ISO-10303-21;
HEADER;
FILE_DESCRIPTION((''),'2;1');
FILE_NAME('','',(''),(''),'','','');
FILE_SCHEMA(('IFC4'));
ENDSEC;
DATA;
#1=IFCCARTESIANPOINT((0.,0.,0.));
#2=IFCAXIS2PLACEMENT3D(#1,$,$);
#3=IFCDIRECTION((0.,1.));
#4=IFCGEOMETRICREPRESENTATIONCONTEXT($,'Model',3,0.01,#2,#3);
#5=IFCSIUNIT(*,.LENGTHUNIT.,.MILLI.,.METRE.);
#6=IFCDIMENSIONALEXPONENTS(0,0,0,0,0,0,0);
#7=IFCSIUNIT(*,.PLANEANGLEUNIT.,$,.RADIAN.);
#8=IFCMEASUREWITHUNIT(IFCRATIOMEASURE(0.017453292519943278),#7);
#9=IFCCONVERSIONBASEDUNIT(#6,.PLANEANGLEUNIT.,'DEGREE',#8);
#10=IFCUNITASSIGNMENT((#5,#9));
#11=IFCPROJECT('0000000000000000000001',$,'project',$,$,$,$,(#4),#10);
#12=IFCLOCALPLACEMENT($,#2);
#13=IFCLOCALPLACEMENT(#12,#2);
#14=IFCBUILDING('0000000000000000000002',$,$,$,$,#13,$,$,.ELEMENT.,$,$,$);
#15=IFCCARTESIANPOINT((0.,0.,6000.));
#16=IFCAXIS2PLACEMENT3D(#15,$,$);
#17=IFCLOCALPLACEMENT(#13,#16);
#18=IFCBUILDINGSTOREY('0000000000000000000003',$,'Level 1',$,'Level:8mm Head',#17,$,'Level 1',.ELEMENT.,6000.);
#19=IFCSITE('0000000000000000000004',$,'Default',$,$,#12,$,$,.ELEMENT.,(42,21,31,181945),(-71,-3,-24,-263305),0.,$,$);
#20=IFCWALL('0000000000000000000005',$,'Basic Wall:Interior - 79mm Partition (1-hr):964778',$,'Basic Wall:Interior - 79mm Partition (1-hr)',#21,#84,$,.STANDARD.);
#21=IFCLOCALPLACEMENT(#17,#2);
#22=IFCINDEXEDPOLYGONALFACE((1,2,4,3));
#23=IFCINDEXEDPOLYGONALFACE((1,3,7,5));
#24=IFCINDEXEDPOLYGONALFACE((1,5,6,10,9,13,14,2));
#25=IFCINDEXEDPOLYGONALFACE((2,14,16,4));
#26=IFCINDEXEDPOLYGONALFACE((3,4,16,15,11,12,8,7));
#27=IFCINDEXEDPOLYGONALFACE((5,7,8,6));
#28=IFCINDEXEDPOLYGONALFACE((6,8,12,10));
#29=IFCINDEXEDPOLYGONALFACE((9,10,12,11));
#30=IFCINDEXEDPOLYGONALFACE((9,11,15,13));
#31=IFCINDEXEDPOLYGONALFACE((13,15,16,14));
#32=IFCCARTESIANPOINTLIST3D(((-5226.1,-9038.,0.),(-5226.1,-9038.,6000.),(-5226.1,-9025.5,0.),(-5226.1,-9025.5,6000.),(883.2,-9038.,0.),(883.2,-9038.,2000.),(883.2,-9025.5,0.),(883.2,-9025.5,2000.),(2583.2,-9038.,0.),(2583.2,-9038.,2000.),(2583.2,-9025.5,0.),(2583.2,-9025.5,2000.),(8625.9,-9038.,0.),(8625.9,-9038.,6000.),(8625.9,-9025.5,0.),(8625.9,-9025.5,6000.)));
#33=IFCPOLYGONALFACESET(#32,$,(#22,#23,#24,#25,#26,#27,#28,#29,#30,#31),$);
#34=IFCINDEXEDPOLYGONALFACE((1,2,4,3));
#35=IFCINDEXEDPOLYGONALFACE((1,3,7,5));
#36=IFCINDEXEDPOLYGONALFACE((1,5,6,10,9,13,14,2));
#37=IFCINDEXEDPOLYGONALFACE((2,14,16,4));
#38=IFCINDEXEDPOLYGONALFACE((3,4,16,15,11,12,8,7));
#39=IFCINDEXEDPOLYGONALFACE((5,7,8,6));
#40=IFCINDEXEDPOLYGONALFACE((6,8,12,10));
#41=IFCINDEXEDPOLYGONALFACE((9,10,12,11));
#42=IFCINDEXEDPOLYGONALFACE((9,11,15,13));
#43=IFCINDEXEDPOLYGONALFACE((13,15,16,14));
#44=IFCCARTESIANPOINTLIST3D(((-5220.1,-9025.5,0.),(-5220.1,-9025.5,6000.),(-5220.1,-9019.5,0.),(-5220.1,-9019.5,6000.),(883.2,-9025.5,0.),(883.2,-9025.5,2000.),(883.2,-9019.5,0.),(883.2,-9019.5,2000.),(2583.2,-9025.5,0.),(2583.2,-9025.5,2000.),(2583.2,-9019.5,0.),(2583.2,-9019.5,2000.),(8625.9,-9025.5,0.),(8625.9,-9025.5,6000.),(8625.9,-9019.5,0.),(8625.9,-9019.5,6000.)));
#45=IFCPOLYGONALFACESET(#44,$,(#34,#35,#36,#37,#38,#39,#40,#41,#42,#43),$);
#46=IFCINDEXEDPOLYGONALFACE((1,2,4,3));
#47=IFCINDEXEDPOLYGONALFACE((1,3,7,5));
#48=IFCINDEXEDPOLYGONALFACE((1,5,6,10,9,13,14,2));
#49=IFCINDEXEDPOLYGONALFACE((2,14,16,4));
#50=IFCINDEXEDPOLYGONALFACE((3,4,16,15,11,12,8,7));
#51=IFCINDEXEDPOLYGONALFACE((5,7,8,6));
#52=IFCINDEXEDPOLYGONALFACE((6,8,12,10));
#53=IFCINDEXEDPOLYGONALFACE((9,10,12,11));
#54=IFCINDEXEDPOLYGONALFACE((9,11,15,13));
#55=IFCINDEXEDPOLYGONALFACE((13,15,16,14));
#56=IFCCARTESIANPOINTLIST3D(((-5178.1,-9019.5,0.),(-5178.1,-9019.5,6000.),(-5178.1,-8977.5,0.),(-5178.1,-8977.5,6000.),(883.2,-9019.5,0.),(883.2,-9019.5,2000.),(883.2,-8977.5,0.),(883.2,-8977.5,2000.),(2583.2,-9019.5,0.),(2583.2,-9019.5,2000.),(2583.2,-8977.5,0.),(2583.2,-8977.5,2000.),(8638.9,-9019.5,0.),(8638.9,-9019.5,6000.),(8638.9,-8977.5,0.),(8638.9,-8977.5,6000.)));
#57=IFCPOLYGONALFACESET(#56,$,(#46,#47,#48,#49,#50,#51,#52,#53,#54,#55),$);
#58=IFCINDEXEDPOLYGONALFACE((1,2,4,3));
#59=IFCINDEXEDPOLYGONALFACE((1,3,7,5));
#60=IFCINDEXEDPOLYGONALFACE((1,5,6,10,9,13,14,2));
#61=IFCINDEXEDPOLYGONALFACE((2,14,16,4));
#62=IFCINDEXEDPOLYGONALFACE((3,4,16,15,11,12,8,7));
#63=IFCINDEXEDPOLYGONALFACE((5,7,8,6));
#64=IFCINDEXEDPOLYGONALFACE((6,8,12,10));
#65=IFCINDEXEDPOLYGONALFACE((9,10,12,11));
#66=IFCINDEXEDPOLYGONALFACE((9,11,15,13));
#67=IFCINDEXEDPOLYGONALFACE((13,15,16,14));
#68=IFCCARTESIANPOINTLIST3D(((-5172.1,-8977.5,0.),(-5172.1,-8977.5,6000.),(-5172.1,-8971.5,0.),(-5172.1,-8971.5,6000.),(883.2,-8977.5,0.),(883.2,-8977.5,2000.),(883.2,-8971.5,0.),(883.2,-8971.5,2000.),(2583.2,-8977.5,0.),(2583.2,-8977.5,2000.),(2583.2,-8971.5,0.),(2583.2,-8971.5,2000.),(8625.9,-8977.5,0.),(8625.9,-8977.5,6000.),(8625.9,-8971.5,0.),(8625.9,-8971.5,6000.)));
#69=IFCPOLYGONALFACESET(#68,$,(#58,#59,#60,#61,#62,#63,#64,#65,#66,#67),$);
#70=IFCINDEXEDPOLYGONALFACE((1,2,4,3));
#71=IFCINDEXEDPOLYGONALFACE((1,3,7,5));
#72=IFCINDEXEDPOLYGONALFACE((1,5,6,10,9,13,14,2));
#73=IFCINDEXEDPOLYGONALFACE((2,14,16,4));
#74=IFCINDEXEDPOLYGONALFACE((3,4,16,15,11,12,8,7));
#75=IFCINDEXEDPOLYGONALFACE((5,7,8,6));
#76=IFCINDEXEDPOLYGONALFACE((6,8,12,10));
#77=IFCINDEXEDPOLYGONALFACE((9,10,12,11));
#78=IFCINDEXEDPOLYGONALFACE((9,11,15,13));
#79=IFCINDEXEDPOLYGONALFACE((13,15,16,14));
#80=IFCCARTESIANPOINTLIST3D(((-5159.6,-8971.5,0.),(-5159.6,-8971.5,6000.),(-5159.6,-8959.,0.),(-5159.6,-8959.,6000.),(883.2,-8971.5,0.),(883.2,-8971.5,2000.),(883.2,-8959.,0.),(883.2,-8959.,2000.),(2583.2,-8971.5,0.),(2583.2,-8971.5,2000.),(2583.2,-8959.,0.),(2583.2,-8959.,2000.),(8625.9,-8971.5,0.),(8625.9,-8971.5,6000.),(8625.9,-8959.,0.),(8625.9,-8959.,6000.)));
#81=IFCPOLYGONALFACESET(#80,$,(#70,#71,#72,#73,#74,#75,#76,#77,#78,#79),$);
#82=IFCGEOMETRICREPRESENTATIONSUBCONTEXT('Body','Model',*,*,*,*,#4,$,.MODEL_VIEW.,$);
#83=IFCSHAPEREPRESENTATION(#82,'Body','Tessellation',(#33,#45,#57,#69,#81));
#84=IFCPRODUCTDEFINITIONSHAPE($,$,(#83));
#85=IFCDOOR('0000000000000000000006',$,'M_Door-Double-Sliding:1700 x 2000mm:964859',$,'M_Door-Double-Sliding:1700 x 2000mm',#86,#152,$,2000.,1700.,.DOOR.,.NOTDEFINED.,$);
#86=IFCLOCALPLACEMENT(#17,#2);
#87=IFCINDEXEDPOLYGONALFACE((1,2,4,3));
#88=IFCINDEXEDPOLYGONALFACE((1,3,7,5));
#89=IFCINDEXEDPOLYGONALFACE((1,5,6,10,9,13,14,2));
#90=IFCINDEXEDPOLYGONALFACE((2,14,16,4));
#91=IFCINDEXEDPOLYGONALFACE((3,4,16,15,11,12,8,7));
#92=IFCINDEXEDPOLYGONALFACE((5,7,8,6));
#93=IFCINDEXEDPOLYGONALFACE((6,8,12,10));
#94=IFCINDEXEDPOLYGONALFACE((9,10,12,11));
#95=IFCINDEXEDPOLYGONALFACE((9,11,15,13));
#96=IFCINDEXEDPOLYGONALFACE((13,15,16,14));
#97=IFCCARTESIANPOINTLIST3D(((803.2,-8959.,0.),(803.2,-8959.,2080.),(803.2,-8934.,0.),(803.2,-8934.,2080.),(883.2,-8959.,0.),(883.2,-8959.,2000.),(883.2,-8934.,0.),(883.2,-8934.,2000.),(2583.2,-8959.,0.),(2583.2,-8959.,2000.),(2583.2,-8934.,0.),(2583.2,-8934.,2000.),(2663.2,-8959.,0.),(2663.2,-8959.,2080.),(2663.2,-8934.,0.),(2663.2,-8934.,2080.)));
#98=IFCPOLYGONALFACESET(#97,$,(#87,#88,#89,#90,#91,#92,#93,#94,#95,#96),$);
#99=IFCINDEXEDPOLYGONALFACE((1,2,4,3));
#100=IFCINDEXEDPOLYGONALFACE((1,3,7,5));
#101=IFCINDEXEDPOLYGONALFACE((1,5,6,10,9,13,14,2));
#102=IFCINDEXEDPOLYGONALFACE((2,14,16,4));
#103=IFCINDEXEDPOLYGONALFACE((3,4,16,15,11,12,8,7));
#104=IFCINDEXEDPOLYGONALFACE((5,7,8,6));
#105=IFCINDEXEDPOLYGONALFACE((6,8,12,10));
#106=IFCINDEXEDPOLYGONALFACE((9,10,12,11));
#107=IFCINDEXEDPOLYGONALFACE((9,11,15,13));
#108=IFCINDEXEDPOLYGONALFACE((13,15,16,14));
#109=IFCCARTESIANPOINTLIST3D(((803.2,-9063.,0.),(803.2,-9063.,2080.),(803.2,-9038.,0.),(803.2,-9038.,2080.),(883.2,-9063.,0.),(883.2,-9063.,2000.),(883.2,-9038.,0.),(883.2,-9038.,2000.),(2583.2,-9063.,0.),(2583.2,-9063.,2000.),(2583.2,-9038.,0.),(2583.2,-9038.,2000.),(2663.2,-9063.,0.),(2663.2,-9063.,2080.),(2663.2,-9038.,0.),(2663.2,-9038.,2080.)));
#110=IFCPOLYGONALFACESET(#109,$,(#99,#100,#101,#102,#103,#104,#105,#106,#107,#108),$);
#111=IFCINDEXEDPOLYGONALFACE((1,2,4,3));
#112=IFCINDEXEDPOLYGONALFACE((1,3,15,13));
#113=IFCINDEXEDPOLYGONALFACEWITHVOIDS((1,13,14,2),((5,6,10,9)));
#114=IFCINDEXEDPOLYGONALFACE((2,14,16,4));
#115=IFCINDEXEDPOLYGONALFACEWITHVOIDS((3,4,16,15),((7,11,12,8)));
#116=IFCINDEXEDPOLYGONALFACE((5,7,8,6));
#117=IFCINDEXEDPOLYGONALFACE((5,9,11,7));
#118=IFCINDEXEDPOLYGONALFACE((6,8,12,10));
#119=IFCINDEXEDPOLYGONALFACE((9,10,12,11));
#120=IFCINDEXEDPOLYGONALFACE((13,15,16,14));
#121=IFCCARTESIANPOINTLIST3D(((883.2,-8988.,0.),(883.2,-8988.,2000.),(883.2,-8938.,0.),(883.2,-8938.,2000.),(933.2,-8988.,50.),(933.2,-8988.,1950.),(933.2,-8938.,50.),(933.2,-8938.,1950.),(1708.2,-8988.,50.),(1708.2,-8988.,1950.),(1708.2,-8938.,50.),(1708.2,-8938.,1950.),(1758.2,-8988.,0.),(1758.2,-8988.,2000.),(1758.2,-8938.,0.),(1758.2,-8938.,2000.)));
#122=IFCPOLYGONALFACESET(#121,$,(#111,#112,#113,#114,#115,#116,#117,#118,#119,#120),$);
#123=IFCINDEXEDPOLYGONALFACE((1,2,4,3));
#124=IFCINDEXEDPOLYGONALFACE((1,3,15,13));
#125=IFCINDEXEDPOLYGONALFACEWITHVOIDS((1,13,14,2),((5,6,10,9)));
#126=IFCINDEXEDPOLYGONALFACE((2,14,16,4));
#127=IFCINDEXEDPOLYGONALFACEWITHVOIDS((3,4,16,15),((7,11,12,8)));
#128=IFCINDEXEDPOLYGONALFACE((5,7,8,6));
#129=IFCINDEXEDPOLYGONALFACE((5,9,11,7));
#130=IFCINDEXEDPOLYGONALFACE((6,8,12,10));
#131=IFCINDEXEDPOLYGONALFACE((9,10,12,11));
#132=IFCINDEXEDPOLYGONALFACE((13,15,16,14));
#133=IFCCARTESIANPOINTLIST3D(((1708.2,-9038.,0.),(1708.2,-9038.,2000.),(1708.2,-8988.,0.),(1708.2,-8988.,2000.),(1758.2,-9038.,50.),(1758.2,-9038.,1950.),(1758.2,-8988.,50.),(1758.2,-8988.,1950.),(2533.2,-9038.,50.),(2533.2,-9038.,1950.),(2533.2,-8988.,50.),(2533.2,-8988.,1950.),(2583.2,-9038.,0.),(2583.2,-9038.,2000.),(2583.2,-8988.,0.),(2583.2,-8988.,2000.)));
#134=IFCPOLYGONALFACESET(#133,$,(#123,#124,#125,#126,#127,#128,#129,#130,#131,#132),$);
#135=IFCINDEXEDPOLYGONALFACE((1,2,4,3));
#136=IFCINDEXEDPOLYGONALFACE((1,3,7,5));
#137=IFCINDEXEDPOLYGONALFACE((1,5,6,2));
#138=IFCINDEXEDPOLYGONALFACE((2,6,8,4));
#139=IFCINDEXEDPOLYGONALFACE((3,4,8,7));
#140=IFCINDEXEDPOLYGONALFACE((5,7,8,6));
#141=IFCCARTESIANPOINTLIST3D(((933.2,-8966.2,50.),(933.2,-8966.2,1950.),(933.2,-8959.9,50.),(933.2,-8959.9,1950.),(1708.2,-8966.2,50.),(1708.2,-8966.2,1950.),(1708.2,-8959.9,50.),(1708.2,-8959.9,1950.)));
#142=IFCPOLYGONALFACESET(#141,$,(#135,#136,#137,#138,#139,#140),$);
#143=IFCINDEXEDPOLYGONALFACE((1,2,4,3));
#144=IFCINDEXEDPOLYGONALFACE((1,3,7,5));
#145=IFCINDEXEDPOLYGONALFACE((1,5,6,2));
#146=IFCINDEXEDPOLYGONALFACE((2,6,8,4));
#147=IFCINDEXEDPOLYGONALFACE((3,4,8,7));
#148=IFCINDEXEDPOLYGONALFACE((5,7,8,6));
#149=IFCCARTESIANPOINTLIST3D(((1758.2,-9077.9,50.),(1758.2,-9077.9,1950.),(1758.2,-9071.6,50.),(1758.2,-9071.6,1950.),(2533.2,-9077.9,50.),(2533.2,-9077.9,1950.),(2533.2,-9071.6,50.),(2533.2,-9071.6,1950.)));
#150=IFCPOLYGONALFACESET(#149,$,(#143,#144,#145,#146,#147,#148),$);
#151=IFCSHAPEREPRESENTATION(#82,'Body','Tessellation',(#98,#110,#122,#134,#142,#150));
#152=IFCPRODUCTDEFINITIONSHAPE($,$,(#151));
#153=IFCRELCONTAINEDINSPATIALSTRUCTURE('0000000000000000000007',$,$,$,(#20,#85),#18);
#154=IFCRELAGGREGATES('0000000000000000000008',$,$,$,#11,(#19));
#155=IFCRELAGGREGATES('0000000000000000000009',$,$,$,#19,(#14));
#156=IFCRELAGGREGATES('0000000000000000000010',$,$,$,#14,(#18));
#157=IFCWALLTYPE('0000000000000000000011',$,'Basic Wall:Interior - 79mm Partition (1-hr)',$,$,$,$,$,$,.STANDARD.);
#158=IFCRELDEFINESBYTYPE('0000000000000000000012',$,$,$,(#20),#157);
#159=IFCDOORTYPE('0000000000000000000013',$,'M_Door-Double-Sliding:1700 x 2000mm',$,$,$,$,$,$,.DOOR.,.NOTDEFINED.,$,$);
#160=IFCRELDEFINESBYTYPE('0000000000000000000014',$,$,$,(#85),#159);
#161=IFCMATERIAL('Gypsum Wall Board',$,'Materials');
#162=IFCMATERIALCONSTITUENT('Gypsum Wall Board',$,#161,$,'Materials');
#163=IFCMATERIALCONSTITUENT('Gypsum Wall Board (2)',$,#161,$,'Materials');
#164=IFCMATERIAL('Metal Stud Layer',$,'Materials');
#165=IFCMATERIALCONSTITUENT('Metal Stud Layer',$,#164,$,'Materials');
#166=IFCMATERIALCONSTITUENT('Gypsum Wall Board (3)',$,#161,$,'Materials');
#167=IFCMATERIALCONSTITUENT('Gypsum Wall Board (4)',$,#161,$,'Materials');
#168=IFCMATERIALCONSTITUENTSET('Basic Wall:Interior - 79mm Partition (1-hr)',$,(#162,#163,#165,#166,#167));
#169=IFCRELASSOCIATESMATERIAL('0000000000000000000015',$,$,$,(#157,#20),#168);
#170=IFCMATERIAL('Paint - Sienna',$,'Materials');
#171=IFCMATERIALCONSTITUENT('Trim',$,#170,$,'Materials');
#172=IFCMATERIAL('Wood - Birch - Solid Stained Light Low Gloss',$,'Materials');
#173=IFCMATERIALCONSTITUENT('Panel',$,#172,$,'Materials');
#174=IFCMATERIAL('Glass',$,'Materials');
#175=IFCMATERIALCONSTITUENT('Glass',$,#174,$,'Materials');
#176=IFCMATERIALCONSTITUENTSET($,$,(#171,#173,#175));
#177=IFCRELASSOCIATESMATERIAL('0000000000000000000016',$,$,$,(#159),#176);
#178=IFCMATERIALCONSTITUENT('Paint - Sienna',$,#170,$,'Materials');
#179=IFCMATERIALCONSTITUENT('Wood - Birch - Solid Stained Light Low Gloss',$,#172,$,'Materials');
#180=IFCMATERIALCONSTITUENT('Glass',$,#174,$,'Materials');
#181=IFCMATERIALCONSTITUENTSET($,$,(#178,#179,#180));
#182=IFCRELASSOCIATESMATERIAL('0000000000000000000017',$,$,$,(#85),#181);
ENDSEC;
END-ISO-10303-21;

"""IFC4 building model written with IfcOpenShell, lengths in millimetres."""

from ifc_helpers import new_model, entity, si_unit, converted_unit, direction, frame, origin, place, context, subcontext, project, spatial, indexed_curve, outline, extrude, source, transform, mapped, material, constituent, constituent_set, type_object, type_shapes, element, fill, save


model = new_model("IFC4")

# Units and contexts
model_context = context("Model", 3, precision=0.01, world=origin(), true_north=direction((0.0, 1.0)))
body_context = subcontext(model_context, "Body", "Model", "MODEL_VIEW")
ifc_project = project(units=[si_unit("LENGTHUNIT", "METRE", prefix="MILLI"), converted_unit("PLANEANGLEUNIT", "DEGREE", entity("IfcRatioMeasure", 0.017453292519943278), si_unit("PLANEANGLEUNIT", "RADIAN"), dimensions=[0, 0, 0, 0, 0, 0, 0])], contexts=[model_context])

# Site, building, storey
site_placement = place(None, origin())
site = spatial("IfcSite", under=ifc_project, at=site_placement, Name="Default", CompositionType="ELEMENT", RefLatitude=(42, 21, 31, 181945), RefLongitude=(-71, -3, -24, -263305), RefElevation=0.0)
building_placement = place(site_placement, origin())
building = spatial("IfcBuilding", under=site, at=building_placement, CompositionType="ELEMENT")
storey_placement = place(building_placement, frame((0.0, 0.0, 6000.0)))
storey = spatial("IfcBuildingStorey", under=building, at=storey_placement, Name="Level 1", ObjectType="Level:8mm Head", LongName="Level 1", CompositionType="ELEMENT", Elevation=6000.0)

# Shared definitions
ifc_material_1 = material(Name="Gypsum Wall Board", Category="Materials")
ifc_constituent_1 = constituent(ifc_material_1, Name="Gypsum Wall Board", Category="Materials")
ifc_constituent_2 = constituent(ifc_material_1, Name="Gypsum Wall Board (2)", Category="Materials")
ifc_material_2 = material(Name="Metal Stud Layer", Category="Materials")
ifc_constituent_3 = constituent(ifc_material_2, Name="Metal Stud Layer", Category="Materials")
ifc_constituent_4 = constituent(ifc_material_1, Name="Gypsum Wall Board (3)", Category="Materials")
ifc_constituent_5 = constituent(ifc_material_1, Name="Gypsum Wall Board (4)", Category="Materials")
ifc_constituent_set_1 = constituent_set(constituents=[ifc_constituent_1, ifc_constituent_2, ifc_constituent_3, ifc_constituent_4, ifc_constituent_5], Name="Basic Wall:Interior - 79mm Partition (1-hr)")
wall_type = type_object("IfcWallType", Name="Basic Wall:Interior - 79mm Partition (1-hr)", PredefinedType="STANDARD", material=ifc_constituent_set_1)

# Wall, opening, door
ifc_material_3 = material(Name="Paint - Sienna", Category="Materials")
ifc_material_4 = material(Name="Wood - Birch - Solid Stained Light Low Gloss", Category="Materials")
ifc_material_5 = material(Name="Glass", Category="Materials")
ifc_constituent_6 = constituent(ifc_material_3, Name="Trim", Category="Materials")
ifc_constituent_7 = constituent(ifc_material_4, Name="Panel", Category="Materials")
ifc_constituent_8 = constituent(ifc_material_5, Name="Glass", Category="Materials")
ifc_constituent_set_2 = constituent_set(constituents=[ifc_constituent_6, ifc_constituent_7, ifc_constituent_8])
door_type = type_object("IfcDoorType", Name="M_Door-Double-Sliding:1700 x 2000mm", OperationType="NOTDEFINED", PredefinedType="DOOR", material=ifc_constituent_set_2)
shared_shape_1 = source(origin(), body_context, "Body", "SweptSolid", [
    extrude(outline(indexed_curve([(-1020.0, -930.0), (1060.0, -930.0), (1060.0, 930.0), (-1020.0, 930.0), (-1020.0, 850.0), (980.0, 850.0), (980.0, -850.0), (-1020.0, -850.0), (-1020.0, -930.0)], self_intersect=False)), frame((850.0, -25.0, 1020.0), z_axis=(0.0, 1.0, 0.0), x_axis=(0.0, 0.0, 1.0)), (0.0, 0.0, 1.0), 25.0),
    extrude(outline(indexed_curve([(-930.0, -1020.0), (-850.0, -1020.0), (-850.0, 980.0), (850.0, 980.0), (850.0, -1020.0), (930.0, -1020.0), (930.0, 1060.0), (-930.0, 1060.0), (-930.0, -1020.0)], self_intersect=False)), frame((850.0, 79.0, 1020.0), z_axis=(0.0, 1.0, 0.0), x_axis=(-1.0, 0.0, 0.0)), (0.0, 0.0, 1.0), 25.0),
    extrude(outline(indexed_curve([(-437.5, -1000.0), (437.5, -1000.0), (437.5, 1000.0), (-437.5, 1000.0), (-437.5, -1000.0)], self_intersect=False), holes=[indexed_curve([(-387.5, -950.0), (-387.5, 950.0), (387.5, 950.0), (387.5, -950.0), (-387.5, -950.0)], self_intersect=False)]), frame((1262.5, -21.0, 1000.0), z_axis=(0.0, 1.0, 0.0), x_axis=(1.0, 0.0, 0.0)), (0.0, 0.0, 1.0), 50.0),
    extrude(outline(indexed_curve([(-1000.0, -437.5), (1000.0, -437.5), (1000.0, 437.5), (-1000.0, 437.5), (-1000.0, -437.5)], self_intersect=False), holes=[indexed_curve([(-950.0, -387.5), (-950.0, 387.5), (950.0, 387.5), (950.0, -387.5), (-950.0, -387.5)], self_intersect=False)]), frame((437.5, 29.0, 1000.0), z_axis=(0.0, 1.0, 0.0), x_axis=(0.0, 0.0, -1.0)), (0.0, 0.0, 1.0), 50.0),
    extrude(outline(indexed_curve([(-3.2, -387.5), (3.2, -387.5), (3.2, 387.5), (-3.2, 387.5), (-3.2, -387.5)], self_intersect=False)), frame((1262.5, 4.0, 50.0), z_axis=(0.0, 0.0, 1.0), x_axis=(0.0, -1.0, 0.0)), (0.0, 0.0, 1.0), 1900.0),
    extrude(outline(indexed_curve([(-3.2, -387.5), (3.2, -387.5), (3.2, 387.5), (-3.2, 387.5), (-3.2, -387.5)], self_intersect=False)), frame((437.5, 115.7, 50.0), z_axis=(0.0, 0.0, 1.0), x_axis=(0.0, 1.0, 0.0)), (0.0, 0.0, 1.0), 1900.0),
])
type_shapes(door_type, [shared_shape_1])
wall_1_placement = place(storey_placement, frame((-5159.6, -8998.5, 0.0)))
wall_1 = element("IfcWall", 1, at=wall_1_placement, inside=storey, type_object=wall_type, material=ifc_constituent_set_1, Name="Basic Wall:Interior - 79mm Partition (1-hr):964778", ObjectType="Basic Wall:Interior - 79mm Partition (1-hr)", PredefinedType="STANDARD", context=body_context, shape_type="SweptSolid", body=[
    extrude(outline(indexed_curve([(-2000.0, -6942.6), (4000.0, -6942.6), (4000.0, 6909.4), (-2000.0, 6909.4), (-2000.0, 866.6), (0.0, 866.6), (0.0, -833.4), (-2000.0, -833.4), (-2000.0, -6942.6)], self_intersect=False)), frame((6876.1, -39.5, 2000.0), z_axis=(0.0, 1.0, 0.0), x_axis=(0.0, 0.0, 1.0)), (0.0, 0.0, 1.0), 12.5),
    extrude(outline(indexed_curve([(-2000.0, -865.1), (-2000.0, -6907.9), (4000.0, -6907.9), (4000.0, 6938.1), (-2000.0, 6938.1), (-2000.0, 834.9), (0.0, 834.9), (0.0, -865.1), (-2000.0, -865.1)], self_intersect=False)), frame((6877.6, -27.0, 2000.0), z_axis=(0.0, -1.0, 0.0), x_axis=(0.0, 0.0, 1.0)), (0.0, 0.0, -1.0), 6.0),
    extrude(outline(indexed_curve([(-2000.0, -851.4), (-2000.0, -6907.1), (4000.0, -6907.1), (4000.0, 6909.9), (-2000.0, 6909.9), (-2000.0, 848.6), (0.0, 848.6), (0.0, -851.4), (-2000.0, -851.4)], self_intersect=False)), frame((6891.4, -21.0, 2000.0), z_axis=(0.0, -1.0, 0.0), x_axis=(0.0, 0.0, 1.0)), (0.0, 0.0, -1.0), 42.0),
    extrude(outline(indexed_curve([(-2000.0, -853.1), (-2000.0, -6895.9), (4000.0, -6895.9), (4000.0, 6902.1), (-2000.0, 6902.1), (-2000.0, 846.9), (0.0, 846.9), (0.0, -853.1), (-2000.0, -853.1)], self_intersect=False)), frame((6889.6, 21.0, 2000.0), z_axis=(0.0, -1.0, 0.0), x_axis=(0.0, 0.0, 1.0)), (0.0, 0.0, -1.0), 6.0),
    extrude(outline(indexed_curve([(-2000.0, -850.0), (-2000.0, -6892.8), (4000.0, -6892.8), (4000.0, 6892.8), (-2000.0, 6892.8), (-2000.0, 850.0), (0.0, 850.0), (0.0, -850.0), (-2000.0, -850.0)], self_intersect=False)), frame((6892.8, 27.0, 2000.0), z_axis=(0.0, -1.0, 0.0), x_axis=(0.0, 0.0, 1.0)), (0.0, 0.0, -1.0), 12.5),
])
opening_1_placement = place(wall_1_placement, frame((7742.8, 39.5, 0.0)))
opening_1 = element("IfcOpeningElement", 2, at=opening_1_placement, cuts=wall_1, PredefinedType="OPENING", context=body_context, shape_type="SweptSolid", body=[
    extrude(outline(indexed_curve([(2000.0, 0.0), (2000.0, 1700.0), (0.0, 1700.0), (0.0, 0.0), (2000.0, 0.0)], self_intersect=False)), frame((0.0, 0.0, 0.0), z_axis=(0.0, -1.0, 0.0), x_axis=(0.0, 0.0, 1.0)), (0.0, 0.0, 1.0), 79.0),
])
ifc_constituent_9 = constituent(ifc_material_3, Name="Paint - Sienna", Category="Materials")
ifc_constituent_10 = constituent(ifc_material_4, Name="Wood - Birch - Solid Stained Light Low Gloss", Category="Materials")
ifc_constituent_11 = constituent(ifc_material_5, Name="Glass", Category="Materials")
ifc_constituent_set_3 = constituent_set(constituents=[ifc_constituent_9, ifc_constituent_10, ifc_constituent_11])
door_1_placement = place(opening_1_placement, frame((0.0, 0.0, 0.0), z_axis=(0.0, 0.0, 1.0), x_axis=(-1.0, 0.0, 0.0)))
door_1 = element("IfcDoor", 3, at=door_1_placement, inside=storey, type_object=door_type, material=ifc_constituent_set_3, Name="M_Door-Double-Sliding:1700 x 2000mm:964859", ObjectType="M_Door-Double-Sliding:1700 x 2000mm", OperationType="NOTDEFINED", OverallHeight=2000.0, OverallWidth=1700.0, PredefinedType="DOOR", context=body_context, shape_type="MappedRepresentation", body=[
    mapped(shared_shape_1, transform((0.0, 0.0, 0.0), scale=1.0)),
])
fill(opening_1, door_1)

save(model, "model.ifc")
